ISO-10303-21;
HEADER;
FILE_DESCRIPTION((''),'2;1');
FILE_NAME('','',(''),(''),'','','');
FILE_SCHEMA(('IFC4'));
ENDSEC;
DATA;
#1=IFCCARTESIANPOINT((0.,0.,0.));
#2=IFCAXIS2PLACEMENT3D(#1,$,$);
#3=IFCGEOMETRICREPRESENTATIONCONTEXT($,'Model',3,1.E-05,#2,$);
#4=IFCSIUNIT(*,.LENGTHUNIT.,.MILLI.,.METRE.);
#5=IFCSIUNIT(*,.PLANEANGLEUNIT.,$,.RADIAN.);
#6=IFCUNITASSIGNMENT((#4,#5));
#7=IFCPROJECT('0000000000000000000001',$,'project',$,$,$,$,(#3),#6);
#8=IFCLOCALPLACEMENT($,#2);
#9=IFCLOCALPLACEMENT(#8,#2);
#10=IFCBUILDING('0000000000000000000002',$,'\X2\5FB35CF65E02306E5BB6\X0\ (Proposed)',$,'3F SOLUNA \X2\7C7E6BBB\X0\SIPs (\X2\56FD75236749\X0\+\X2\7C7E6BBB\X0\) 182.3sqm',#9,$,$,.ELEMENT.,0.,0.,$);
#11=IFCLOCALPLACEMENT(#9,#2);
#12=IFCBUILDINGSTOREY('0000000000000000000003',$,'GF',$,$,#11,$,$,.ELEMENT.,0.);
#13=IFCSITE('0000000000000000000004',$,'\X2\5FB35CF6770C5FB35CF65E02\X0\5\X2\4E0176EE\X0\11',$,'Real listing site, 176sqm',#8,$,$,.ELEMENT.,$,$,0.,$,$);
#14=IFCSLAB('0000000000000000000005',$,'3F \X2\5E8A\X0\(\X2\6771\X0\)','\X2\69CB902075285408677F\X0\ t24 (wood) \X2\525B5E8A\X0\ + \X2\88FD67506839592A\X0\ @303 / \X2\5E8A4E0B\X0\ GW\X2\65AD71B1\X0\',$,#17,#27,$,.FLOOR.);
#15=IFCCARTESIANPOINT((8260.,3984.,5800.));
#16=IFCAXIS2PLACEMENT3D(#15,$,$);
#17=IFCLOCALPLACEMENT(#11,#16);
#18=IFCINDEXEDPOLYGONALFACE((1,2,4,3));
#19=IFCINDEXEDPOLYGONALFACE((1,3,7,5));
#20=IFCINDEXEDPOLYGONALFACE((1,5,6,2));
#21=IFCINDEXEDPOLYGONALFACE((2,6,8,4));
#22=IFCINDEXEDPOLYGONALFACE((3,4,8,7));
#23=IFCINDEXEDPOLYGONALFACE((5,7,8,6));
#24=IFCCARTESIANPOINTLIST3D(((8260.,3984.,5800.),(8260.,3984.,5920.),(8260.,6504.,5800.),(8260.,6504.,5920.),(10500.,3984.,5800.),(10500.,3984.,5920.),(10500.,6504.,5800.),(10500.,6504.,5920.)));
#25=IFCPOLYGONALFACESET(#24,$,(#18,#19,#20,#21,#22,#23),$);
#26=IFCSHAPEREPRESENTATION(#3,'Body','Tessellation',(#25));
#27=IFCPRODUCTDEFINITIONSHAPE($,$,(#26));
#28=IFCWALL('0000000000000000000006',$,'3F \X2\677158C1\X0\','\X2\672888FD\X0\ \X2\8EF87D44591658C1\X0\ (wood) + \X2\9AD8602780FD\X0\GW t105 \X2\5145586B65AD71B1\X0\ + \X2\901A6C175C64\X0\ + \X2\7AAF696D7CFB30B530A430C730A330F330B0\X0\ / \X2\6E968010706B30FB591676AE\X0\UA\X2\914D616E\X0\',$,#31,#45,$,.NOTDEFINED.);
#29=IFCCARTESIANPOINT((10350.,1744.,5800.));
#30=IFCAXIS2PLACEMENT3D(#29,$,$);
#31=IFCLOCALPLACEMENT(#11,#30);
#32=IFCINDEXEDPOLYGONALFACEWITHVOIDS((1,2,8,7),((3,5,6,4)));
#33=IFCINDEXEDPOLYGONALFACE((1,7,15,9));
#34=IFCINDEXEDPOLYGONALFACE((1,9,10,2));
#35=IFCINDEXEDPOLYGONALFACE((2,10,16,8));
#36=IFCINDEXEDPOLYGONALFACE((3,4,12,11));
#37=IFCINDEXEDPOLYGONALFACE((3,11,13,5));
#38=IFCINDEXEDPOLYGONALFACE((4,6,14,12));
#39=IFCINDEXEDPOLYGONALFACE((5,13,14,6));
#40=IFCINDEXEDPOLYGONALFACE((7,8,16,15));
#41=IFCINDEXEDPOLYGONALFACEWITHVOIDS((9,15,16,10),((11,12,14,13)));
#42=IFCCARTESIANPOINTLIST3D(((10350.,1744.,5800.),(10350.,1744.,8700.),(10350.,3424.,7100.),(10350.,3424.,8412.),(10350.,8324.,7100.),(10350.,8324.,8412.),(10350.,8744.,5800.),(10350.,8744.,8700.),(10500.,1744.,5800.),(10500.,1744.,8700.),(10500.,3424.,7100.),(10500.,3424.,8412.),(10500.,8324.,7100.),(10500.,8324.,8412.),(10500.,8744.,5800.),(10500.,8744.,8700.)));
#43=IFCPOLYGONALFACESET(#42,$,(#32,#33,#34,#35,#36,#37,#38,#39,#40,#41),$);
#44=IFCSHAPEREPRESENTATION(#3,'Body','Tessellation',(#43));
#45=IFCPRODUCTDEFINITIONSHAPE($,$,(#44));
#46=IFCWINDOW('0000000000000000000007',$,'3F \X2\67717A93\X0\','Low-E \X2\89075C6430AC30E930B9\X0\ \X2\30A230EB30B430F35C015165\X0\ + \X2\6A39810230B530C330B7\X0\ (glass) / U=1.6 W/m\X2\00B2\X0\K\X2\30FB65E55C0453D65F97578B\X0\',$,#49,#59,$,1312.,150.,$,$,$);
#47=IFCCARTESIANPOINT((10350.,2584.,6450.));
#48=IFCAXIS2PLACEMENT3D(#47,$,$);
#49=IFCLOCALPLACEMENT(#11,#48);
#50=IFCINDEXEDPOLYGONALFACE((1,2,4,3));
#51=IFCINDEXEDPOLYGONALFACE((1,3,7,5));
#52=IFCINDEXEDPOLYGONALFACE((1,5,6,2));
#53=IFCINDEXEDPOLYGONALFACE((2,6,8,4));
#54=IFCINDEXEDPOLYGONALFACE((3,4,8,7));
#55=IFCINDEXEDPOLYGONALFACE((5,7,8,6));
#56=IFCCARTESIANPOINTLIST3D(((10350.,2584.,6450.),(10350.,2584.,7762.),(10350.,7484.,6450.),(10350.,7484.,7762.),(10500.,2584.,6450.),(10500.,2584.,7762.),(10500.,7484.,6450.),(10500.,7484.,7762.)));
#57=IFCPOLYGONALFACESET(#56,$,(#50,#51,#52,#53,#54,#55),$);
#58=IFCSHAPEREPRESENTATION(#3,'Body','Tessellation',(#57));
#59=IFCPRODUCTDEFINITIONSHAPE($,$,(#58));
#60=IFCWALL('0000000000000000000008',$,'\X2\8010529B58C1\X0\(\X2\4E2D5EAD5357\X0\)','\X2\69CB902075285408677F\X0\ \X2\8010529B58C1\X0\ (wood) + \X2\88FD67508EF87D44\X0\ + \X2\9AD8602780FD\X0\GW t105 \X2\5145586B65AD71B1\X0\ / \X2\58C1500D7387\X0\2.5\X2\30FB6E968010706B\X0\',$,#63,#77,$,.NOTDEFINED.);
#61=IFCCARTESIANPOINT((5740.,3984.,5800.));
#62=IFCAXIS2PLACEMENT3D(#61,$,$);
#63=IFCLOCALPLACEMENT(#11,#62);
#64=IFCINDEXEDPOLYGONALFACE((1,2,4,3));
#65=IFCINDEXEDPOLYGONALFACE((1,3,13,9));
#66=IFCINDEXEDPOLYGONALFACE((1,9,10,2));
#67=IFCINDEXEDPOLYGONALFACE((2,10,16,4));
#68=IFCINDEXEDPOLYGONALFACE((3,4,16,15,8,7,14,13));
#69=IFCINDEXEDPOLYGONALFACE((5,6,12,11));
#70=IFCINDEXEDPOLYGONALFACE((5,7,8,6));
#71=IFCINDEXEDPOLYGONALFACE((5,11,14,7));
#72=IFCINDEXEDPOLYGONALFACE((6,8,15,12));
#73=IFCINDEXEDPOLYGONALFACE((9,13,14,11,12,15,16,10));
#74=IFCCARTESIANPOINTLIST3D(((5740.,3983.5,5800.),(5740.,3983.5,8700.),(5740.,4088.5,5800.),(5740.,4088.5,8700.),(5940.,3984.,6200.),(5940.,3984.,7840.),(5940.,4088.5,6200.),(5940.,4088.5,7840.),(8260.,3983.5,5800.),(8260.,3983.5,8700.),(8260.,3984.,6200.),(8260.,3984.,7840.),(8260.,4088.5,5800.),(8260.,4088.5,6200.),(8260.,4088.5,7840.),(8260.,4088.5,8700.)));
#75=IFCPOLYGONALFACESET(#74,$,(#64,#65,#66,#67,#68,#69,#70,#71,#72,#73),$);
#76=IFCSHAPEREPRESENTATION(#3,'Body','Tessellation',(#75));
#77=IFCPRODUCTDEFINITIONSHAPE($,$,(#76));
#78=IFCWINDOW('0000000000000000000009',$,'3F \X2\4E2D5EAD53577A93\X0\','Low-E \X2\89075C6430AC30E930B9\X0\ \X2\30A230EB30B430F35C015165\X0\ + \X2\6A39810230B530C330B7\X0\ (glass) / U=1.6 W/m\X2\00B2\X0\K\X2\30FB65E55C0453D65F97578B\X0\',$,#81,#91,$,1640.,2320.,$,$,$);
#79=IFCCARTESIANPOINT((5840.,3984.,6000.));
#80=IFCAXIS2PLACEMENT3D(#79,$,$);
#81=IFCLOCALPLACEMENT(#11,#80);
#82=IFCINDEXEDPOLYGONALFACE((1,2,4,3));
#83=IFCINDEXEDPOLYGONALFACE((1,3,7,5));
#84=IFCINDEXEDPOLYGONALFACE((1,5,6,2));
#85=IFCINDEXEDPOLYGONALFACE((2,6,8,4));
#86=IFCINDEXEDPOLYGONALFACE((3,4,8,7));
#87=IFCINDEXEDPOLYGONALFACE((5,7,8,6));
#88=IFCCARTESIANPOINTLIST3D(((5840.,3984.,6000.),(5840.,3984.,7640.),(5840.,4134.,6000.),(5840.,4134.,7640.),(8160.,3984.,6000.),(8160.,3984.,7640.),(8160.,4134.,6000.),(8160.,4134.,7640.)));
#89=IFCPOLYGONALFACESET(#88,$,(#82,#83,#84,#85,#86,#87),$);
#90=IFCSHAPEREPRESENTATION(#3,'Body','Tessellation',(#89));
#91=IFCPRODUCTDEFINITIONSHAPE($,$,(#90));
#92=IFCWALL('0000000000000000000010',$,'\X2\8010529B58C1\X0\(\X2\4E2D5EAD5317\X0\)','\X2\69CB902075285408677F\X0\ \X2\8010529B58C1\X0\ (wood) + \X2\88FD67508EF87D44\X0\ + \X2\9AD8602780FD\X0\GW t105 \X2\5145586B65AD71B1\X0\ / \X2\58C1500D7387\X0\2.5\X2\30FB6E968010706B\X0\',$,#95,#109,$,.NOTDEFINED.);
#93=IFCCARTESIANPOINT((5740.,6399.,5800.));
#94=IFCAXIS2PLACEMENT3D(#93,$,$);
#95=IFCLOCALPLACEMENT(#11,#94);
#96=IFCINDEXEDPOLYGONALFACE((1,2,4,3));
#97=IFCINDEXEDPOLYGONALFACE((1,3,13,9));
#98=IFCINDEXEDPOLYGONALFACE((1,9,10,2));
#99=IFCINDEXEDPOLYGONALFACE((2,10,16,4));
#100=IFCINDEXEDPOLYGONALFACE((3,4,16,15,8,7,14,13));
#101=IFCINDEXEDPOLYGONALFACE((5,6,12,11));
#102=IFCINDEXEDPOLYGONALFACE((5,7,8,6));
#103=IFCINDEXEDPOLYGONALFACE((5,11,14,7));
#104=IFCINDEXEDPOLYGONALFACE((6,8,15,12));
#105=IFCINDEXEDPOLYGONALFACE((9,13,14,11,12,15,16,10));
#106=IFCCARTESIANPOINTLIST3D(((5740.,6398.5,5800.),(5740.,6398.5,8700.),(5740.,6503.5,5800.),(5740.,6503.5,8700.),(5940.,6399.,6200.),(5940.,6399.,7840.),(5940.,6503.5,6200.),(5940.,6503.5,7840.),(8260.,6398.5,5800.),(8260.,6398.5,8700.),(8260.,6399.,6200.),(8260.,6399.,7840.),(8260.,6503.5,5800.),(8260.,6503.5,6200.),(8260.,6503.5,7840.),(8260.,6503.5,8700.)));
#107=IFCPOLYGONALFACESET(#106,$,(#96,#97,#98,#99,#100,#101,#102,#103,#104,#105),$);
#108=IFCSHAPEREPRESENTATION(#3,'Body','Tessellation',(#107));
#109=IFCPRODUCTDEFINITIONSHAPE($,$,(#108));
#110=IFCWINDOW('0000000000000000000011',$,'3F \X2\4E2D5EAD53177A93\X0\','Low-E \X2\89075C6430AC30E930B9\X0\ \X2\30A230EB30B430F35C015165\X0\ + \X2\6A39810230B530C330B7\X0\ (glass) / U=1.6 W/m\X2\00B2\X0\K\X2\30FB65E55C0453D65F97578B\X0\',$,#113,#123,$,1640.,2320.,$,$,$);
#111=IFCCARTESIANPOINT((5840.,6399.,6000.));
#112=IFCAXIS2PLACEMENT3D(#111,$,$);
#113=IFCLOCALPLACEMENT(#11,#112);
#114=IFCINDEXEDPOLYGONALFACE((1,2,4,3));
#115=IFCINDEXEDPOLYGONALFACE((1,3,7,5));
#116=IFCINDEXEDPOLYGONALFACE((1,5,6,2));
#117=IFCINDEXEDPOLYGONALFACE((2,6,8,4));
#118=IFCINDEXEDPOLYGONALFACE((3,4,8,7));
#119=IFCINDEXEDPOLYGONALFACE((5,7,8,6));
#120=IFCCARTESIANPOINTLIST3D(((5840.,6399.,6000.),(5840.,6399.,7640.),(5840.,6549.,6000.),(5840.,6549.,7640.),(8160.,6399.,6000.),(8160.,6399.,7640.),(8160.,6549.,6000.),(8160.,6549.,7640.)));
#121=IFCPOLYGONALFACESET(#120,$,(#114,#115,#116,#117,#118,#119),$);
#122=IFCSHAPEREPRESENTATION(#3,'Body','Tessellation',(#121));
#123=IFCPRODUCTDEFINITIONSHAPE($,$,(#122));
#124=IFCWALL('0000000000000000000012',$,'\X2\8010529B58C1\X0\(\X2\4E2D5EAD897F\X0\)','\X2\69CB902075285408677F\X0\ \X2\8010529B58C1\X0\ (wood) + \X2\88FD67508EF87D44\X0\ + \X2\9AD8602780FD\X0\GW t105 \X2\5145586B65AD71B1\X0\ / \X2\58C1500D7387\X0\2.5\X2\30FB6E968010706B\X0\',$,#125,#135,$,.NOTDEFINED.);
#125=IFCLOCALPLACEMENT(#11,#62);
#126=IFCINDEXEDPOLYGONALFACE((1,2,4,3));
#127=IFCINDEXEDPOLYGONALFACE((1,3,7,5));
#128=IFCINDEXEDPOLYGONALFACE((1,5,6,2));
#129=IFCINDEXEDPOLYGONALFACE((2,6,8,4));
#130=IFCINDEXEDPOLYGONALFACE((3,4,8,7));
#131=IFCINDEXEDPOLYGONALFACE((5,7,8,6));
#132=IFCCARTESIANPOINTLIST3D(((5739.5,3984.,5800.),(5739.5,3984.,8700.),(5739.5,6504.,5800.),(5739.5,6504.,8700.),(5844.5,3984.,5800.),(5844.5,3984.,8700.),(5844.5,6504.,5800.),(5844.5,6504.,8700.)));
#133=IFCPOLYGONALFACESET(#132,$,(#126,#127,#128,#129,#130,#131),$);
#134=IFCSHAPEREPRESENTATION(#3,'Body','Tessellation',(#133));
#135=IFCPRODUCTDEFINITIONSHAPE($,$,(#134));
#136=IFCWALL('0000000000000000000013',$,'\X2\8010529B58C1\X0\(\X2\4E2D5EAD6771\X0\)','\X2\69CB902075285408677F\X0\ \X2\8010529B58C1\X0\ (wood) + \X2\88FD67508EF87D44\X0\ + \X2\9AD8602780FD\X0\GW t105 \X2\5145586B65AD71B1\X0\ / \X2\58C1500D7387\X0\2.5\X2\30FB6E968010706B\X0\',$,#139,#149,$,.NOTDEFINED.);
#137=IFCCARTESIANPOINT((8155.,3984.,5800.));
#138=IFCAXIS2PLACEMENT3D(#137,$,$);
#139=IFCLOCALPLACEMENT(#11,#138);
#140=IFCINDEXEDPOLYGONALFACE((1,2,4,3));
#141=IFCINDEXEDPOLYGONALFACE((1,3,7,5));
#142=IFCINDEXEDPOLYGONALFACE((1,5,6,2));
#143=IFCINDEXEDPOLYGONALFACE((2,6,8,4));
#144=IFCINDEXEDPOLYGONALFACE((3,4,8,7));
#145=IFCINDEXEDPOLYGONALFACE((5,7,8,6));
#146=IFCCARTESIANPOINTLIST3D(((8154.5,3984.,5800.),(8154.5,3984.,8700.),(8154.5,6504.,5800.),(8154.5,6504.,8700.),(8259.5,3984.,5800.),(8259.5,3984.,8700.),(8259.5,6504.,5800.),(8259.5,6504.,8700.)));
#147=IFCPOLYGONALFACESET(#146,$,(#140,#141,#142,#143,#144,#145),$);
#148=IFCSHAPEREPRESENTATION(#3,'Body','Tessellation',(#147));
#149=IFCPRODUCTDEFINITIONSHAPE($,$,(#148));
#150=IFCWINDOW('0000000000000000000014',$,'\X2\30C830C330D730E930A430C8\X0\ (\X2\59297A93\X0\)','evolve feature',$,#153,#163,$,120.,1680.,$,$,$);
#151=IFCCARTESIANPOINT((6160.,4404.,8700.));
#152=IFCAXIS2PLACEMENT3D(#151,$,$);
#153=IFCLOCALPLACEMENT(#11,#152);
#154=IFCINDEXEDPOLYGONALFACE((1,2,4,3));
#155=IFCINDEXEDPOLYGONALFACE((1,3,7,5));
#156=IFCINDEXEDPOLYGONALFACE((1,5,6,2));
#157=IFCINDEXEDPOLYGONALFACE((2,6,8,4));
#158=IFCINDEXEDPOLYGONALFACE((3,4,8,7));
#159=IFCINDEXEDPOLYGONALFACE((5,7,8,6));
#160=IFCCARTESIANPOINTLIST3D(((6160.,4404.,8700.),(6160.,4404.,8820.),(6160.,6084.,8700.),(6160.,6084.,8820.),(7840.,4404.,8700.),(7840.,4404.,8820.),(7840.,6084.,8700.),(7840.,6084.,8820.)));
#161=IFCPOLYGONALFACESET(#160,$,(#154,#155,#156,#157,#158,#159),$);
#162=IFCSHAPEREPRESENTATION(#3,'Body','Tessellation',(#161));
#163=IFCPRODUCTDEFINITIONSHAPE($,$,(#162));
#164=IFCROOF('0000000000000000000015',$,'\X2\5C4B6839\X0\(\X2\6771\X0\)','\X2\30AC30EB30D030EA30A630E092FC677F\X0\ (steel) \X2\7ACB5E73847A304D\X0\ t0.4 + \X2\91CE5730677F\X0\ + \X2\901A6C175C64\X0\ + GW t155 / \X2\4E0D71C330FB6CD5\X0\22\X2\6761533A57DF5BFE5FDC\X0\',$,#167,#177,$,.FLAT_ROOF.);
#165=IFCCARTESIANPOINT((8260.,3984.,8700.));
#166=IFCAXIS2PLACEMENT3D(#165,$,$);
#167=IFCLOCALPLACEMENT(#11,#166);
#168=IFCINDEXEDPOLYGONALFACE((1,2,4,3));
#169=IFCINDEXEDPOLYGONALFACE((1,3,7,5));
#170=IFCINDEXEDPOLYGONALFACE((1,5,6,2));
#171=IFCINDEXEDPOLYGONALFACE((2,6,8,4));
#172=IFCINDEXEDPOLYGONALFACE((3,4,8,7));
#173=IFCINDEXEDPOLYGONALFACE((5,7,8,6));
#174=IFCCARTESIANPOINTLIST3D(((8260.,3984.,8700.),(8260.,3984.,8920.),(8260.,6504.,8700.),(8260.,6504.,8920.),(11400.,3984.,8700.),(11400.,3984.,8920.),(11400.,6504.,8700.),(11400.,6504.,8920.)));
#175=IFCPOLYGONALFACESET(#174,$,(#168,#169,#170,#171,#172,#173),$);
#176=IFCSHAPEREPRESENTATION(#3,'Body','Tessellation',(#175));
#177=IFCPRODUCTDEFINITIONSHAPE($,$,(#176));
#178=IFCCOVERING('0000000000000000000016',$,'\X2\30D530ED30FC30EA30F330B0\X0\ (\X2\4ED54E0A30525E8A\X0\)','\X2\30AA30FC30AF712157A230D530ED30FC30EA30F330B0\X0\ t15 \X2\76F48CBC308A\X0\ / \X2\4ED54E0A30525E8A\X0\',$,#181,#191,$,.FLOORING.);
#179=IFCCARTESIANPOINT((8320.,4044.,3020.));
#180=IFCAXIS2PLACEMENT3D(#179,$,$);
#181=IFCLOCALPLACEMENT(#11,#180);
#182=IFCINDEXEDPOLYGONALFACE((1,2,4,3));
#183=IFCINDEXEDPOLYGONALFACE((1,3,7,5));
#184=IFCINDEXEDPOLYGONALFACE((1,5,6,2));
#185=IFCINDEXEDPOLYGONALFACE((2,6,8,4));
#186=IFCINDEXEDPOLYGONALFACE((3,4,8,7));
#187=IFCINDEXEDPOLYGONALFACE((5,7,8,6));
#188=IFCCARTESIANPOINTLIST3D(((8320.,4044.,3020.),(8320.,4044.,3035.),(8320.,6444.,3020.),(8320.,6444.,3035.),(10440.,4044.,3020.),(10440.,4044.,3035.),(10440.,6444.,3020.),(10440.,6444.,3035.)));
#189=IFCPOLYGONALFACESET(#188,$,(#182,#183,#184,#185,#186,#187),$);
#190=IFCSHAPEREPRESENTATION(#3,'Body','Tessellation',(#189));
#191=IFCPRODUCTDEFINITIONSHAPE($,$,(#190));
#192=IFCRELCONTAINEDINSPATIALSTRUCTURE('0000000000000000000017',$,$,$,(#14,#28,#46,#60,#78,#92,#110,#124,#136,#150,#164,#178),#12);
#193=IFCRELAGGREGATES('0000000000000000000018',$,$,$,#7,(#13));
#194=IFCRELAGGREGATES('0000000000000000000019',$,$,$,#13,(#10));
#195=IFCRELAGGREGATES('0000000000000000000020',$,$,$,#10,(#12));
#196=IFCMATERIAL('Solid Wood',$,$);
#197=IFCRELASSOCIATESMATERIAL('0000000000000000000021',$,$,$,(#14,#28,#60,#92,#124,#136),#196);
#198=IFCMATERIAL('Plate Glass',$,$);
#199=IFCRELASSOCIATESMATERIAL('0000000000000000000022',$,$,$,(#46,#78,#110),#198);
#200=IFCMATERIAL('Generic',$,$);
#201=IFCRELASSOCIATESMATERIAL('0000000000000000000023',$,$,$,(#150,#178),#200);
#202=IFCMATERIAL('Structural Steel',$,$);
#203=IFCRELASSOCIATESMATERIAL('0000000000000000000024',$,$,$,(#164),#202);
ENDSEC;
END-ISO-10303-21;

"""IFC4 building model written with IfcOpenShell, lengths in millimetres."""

from ifc_helpers import new_model, si_unit, frame, frame_2d, origin, place, context, project, spatial, rectangle, extrude, material, element, fill, save


model = new_model("IFC4")

# Units and contexts
model_context = context("Model", 3, precision=1e-05, world=origin())
ifc_project = project(units=[si_unit("LENGTHUNIT", "METRE", prefix="MILLI"), si_unit("PLANEANGLEUNIT", "RADIAN")], contexts=[model_context])

# Site, building, storey
site_placement = place(None, origin())
site = spatial("IfcSite", under=ifc_project, at=site_placement, Name="徳島県徳島市5丁目11", ObjectType="Real listing site, 176sqm", CompositionType="ELEMENT", RefElevation=0.0)
building_placement = place(site_placement, origin())
building = spatial("IfcBuilding", under=site, at=building_placement, Name="徳島市の家 (Proposed)", ObjectType="3F SOLUNA 籾殻SIPs (国産杉+籾殻) 182.3sqm", CompositionType="ELEMENT", ElevationOfRefHeight=0.0, ElevationOfTerrain=0.0)
storey_placement = place(building_placement, origin())
storey = spatial("IfcBuildingStorey", under=building, at=storey_placement, Name="GF", CompositionType="ELEMENT", Elevation=0.0)

# Slab
ifc_material_1 = material(Name="Solid Wood")
slab_placement = place(storey_placement, frame((8260.0, 3984.0, 5800.0)))
element("IfcSlab", 1, at=slab_placement, inside=storey, material=ifc_material_1, Name="3F 床(東)", Description="構造用合板 t24 (wood) 剛床 + 製材根太 @303 / 床下 GW断熱", PredefinedType="FLOOR", context=model_context, shape_type="SweptSolid", body=[
    extrude(rectangle(XDim=2240.0, YDim=2520.0, at=frame_2d((1120.0, 1260.0))), frame((8260.0, 3984.0, 5800.0)), (0.0, 0.0, 1.0), 120.0),
])

# Walls, openings, windows
wall_1_placement = place(storey_placement, frame((10350.0, 1744.0, 5800.0)))
wall_1 = element("IfcWall", 2, at=wall_1_placement, inside=storey, material=ifc_material_1, Name="3F 東壁", Description="木製 軸組外壁 (wood) + 高性能GW t105 充填断熱 + 通気層 + 窯業系サイディング / 準耐火・外皮UA配慮", PredefinedType="NOTDEFINED", context=model_context, shape_type="SweptSolid", body=[
    extrude(rectangle(XDim=150.0, YDim=7000.0, at=frame_2d((75.0, 3500.0))), frame((10350.0, 1744.0, 5800.0)), (0.0, 0.0, 1.0), 2900.0),
])
opening_1_placement = place(storey_placement, frame((10350.0, 2584.0, 6450.0)))
opening_1 = element("IfcOpeningElement", 3, at=opening_1_placement, cuts=wall_1, PredefinedType="NOTDEFINED", context=model_context, shape_type="SweptSolid", body=[
    extrude(rectangle(XDim=150.0, YDim=4900.0, at=frame_2d((75.0, 2450.0))), frame((10350.0, 2584.0, 6450.0)), (0.0, 0.0, 1.0), 1312.0),
])
ifc_material_2 = material(Name="Plate Glass")
window_1_placement = place(storey_placement, frame((10350.0, 2584.0, 6450.0)))
window_1 = element("IfcWindow", 4, at=window_1_placement, inside=storey, material=ifc_material_2, Name="3F 東窓", Description="Low-E 複層ガラス アルゴン封入 + 樹脂サッシ (glass) / U=1.6 W/m²K・日射取得型", OverallHeight=1312.0, OverallWidth=150.0, context=model_context, shape_type="SweptSolid", body=[
    extrude(rectangle(XDim=150.0, YDim=4900.0, at=frame_2d((75.0, 2450.0))), frame((10350.0, 2584.0, 6450.0)), (0.0, 0.0, 1.0), 1312.0),
])
fill(opening_1, window_1)
wall_2_placement = place(storey_placement, frame((5740.0, 3984.0, 5800.0)))
wall_2 = element("IfcWall", 5, at=wall_2_placement, inside=storey, material=ifc_material_1, Name="耐力壁(中庭南)", Description="構造用合板 耐力壁 (wood) + 製材軸組 + 高性能GW t105 充填断熱 / 壁倍率2.5・準耐火", PredefinedType="NOTDEFINED", context=model_context, shape_type="SweptSolid", body=[
    extrude(rectangle(XDim=2520.0, YDim=105.0, at=frame_2d((1260.0, 52.0))), frame((5740.0, 3984.0, 5800.0)), (0.0, 0.0, 1.0), 2900.0),
])
opening_2_placement = place(storey_placement, frame((5840.0, 3984.0, 6000.0)))
opening_2 = element("IfcOpeningElement", 6, at=opening_2_placement, cuts=wall_2, PredefinedType="NOTDEFINED", context=model_context, shape_type="SweptSolid", body=[
    extrude(rectangle(XDim=2320.0, YDim=150.0, at=frame_2d((1160.0, 75.0))), frame((5840.0, 3984.0, 6000.0)), (0.0, 0.0, 1.0), 1640.0),
])
window_2_placement = place(storey_placement, frame((5840.0, 3984.0, 6000.0)))
window_2 = element("IfcWindow", 7, at=window_2_placement, inside=storey, material=ifc_material_2, Name="3F 中庭南窓", Description="Low-E 複層ガラス アルゴン封入 + 樹脂サッシ (glass) / U=1.6 W/m²K・日射取得型", OverallHeight=1640.0, OverallWidth=2320.0, context=model_context, shape_type="SweptSolid", body=[
    extrude(rectangle(XDim=2320.0, YDim=150.0, at=frame_2d((1160.0, 75.0))), frame((5840.0, 3984.0, 6000.0)), (0.0, 0.0, 1.0), 1640.0),
])
fill(opening_2, window_2)
wall_3_placement = place(storey_placement, frame((5740.0, 6399.0, 5800.0)))
wall_3 = element("IfcWall", 8, at=wall_3_placement, inside=storey, material=ifc_material_1, Name="耐力壁(中庭北)", Description="構造用合板 耐力壁 (wood) + 製材軸組 + 高性能GW t105 充填断熱 / 壁倍率2.5・準耐火", PredefinedType="NOTDEFINED", context=model_context, shape_type="SweptSolid", body=[
    extrude(rectangle(XDim=2520.0, YDim=105.0, at=frame_2d((1260.0, 52.0))), frame((5740.0, 6399.0, 5800.0)), (0.0, 0.0, 1.0), 2900.0),
])
opening_3_placement = place(storey_placement, frame((5840.0, 6399.0, 6000.0)))
opening_3 = element("IfcOpeningElement", 9, at=opening_3_placement, cuts=wall_3, PredefinedType="NOTDEFINED", context=model_context, shape_type="SweptSolid", body=[
    extrude(rectangle(XDim=2320.0, YDim=150.0, at=frame_2d((1160.0, 75.0))), frame((5840.0, 6399.0, 6000.0)), (0.0, 0.0, 1.0), 1640.0),
])
window_3_placement = place(storey_placement, frame((5840.0, 6399.0, 6000.0)))
window_3 = element("IfcWindow", 10, at=window_3_placement, inside=storey, material=ifc_material_2, Name="3F 中庭北窓", Description="Low-E 複層ガラス アルゴン封入 + 樹脂サッシ (glass) / U=1.6 W/m²K・日射取得型", OverallHeight=1640.0, OverallWidth=2320.0, context=model_context, shape_type="SweptSolid", body=[
    extrude(rectangle(XDim=2320.0, YDim=150.0, at=frame_2d((1160.0, 75.0))), frame((5840.0, 6399.0, 6000.0)), (0.0, 0.0, 1.0), 1640.0),
])
fill(opening_3, window_3)

# Walls
wall_4_placement = place(storey_placement, frame((5740.0, 3984.0, 5800.0)))
element("IfcWall", 11, at=wall_4_placement, inside=storey, material=ifc_material_1, Name="耐力壁(中庭西)", Description="構造用合板 耐力壁 (wood) + 製材軸組 + 高性能GW t105 充填断熱 / 壁倍率2.5・準耐火", PredefinedType="NOTDEFINED", context=model_context, shape_type="SweptSolid", body=[
    extrude(rectangle(XDim=105.0, YDim=2520.0, at=frame_2d((52.0, 1260.0))), frame((5740.0, 3984.0, 5800.0)), (0.0, 0.0, 1.0), 2900.0),
])
wall_5_placement = place(storey_placement, frame((8155.0, 3984.0, 5800.0)))
element("IfcWall", 12, at=wall_5_placement, inside=storey, material=ifc_material_1, Name="耐力壁(中庭東)", Description="構造用合板 耐力壁 (wood) + 製材軸組 + 高性能GW t105 充填断熱 / 壁倍率2.5・準耐火", PredefinedType="NOTDEFINED", context=model_context, shape_type="SweptSolid", body=[
    extrude(rectangle(XDim=105.0, YDim=2520.0, at=frame_2d((52.0, 1260.0))), frame((8155.0, 3984.0, 5800.0)), (0.0, 0.0, 1.0), 2900.0),
])

# Window
ifc_material_3 = material(Name="Generic")
window_4_placement = place(storey_placement, frame((6160.0, 4404.0, 8700.0)))
element("IfcWindow", 13, at=window_4_placement, inside=storey, material=ifc_material_3, Name="トップライト (天窓)", Description="evolve feature", OverallHeight=120.0, OverallWidth=1680.0, context=model_context, shape_type="SweptSolid", body=[
    extrude(rectangle(XDim=1680.0, YDim=1680.0, at=frame_2d((840.0, 840.0))), frame((6160.0, 4404.0, 8700.0)), (0.0, 0.0, 1.0), 120.0),
])

# Roof
ifc_material_4 = material(Name="Structural Steel")
for number, where, name in (
    (14, (8260.0, 3984.0, 8700.0), "屋根(東)"),
):
    element("IfcRoof", number, at=place(storey_placement, frame(where)), inside=storey, material=ifc_material_4, Name=name, Description="ガルバリウム鋼板 (steel) 立平葺き t0.4 + 野地板 + 通気層 + GW t155 / 不燃・法22条区域対応", PredefinedType="FLAT_ROOF", context=model_context, shape_type="SweptSolid", body=[
        extrude(rectangle(XDim=3140.0, YDim=2520.0, at=frame_2d((1570.0, 1260.0))), frame((8260.0, 3984.0, 8700.0)), (0.0, 0.0, 1.0), 220.0),
    ])

# Covering
covering_1_placement = place(storey_placement, frame((8320.0, 4044.0, 3020.0)))
element("IfcCovering", 15, at=covering_1_placement, inside=storey, material=ifc_material_3, Name="フローリング (仕上げ床)", Description="オーク無垢フローリング t15 直貼り / 仕上げ床", PredefinedType="FLOORING", context=model_context, shape_type="SweptSolid", body=[
    extrude(rectangle(XDim=2120.0, YDim=2400.0, at=frame_2d((1060.0, 1200.0))), frame((8320.0, 4044.0, 3020.0)), (0.0, 0.0, 1.0), 15.0),
])

save(model, "model.ifc")
